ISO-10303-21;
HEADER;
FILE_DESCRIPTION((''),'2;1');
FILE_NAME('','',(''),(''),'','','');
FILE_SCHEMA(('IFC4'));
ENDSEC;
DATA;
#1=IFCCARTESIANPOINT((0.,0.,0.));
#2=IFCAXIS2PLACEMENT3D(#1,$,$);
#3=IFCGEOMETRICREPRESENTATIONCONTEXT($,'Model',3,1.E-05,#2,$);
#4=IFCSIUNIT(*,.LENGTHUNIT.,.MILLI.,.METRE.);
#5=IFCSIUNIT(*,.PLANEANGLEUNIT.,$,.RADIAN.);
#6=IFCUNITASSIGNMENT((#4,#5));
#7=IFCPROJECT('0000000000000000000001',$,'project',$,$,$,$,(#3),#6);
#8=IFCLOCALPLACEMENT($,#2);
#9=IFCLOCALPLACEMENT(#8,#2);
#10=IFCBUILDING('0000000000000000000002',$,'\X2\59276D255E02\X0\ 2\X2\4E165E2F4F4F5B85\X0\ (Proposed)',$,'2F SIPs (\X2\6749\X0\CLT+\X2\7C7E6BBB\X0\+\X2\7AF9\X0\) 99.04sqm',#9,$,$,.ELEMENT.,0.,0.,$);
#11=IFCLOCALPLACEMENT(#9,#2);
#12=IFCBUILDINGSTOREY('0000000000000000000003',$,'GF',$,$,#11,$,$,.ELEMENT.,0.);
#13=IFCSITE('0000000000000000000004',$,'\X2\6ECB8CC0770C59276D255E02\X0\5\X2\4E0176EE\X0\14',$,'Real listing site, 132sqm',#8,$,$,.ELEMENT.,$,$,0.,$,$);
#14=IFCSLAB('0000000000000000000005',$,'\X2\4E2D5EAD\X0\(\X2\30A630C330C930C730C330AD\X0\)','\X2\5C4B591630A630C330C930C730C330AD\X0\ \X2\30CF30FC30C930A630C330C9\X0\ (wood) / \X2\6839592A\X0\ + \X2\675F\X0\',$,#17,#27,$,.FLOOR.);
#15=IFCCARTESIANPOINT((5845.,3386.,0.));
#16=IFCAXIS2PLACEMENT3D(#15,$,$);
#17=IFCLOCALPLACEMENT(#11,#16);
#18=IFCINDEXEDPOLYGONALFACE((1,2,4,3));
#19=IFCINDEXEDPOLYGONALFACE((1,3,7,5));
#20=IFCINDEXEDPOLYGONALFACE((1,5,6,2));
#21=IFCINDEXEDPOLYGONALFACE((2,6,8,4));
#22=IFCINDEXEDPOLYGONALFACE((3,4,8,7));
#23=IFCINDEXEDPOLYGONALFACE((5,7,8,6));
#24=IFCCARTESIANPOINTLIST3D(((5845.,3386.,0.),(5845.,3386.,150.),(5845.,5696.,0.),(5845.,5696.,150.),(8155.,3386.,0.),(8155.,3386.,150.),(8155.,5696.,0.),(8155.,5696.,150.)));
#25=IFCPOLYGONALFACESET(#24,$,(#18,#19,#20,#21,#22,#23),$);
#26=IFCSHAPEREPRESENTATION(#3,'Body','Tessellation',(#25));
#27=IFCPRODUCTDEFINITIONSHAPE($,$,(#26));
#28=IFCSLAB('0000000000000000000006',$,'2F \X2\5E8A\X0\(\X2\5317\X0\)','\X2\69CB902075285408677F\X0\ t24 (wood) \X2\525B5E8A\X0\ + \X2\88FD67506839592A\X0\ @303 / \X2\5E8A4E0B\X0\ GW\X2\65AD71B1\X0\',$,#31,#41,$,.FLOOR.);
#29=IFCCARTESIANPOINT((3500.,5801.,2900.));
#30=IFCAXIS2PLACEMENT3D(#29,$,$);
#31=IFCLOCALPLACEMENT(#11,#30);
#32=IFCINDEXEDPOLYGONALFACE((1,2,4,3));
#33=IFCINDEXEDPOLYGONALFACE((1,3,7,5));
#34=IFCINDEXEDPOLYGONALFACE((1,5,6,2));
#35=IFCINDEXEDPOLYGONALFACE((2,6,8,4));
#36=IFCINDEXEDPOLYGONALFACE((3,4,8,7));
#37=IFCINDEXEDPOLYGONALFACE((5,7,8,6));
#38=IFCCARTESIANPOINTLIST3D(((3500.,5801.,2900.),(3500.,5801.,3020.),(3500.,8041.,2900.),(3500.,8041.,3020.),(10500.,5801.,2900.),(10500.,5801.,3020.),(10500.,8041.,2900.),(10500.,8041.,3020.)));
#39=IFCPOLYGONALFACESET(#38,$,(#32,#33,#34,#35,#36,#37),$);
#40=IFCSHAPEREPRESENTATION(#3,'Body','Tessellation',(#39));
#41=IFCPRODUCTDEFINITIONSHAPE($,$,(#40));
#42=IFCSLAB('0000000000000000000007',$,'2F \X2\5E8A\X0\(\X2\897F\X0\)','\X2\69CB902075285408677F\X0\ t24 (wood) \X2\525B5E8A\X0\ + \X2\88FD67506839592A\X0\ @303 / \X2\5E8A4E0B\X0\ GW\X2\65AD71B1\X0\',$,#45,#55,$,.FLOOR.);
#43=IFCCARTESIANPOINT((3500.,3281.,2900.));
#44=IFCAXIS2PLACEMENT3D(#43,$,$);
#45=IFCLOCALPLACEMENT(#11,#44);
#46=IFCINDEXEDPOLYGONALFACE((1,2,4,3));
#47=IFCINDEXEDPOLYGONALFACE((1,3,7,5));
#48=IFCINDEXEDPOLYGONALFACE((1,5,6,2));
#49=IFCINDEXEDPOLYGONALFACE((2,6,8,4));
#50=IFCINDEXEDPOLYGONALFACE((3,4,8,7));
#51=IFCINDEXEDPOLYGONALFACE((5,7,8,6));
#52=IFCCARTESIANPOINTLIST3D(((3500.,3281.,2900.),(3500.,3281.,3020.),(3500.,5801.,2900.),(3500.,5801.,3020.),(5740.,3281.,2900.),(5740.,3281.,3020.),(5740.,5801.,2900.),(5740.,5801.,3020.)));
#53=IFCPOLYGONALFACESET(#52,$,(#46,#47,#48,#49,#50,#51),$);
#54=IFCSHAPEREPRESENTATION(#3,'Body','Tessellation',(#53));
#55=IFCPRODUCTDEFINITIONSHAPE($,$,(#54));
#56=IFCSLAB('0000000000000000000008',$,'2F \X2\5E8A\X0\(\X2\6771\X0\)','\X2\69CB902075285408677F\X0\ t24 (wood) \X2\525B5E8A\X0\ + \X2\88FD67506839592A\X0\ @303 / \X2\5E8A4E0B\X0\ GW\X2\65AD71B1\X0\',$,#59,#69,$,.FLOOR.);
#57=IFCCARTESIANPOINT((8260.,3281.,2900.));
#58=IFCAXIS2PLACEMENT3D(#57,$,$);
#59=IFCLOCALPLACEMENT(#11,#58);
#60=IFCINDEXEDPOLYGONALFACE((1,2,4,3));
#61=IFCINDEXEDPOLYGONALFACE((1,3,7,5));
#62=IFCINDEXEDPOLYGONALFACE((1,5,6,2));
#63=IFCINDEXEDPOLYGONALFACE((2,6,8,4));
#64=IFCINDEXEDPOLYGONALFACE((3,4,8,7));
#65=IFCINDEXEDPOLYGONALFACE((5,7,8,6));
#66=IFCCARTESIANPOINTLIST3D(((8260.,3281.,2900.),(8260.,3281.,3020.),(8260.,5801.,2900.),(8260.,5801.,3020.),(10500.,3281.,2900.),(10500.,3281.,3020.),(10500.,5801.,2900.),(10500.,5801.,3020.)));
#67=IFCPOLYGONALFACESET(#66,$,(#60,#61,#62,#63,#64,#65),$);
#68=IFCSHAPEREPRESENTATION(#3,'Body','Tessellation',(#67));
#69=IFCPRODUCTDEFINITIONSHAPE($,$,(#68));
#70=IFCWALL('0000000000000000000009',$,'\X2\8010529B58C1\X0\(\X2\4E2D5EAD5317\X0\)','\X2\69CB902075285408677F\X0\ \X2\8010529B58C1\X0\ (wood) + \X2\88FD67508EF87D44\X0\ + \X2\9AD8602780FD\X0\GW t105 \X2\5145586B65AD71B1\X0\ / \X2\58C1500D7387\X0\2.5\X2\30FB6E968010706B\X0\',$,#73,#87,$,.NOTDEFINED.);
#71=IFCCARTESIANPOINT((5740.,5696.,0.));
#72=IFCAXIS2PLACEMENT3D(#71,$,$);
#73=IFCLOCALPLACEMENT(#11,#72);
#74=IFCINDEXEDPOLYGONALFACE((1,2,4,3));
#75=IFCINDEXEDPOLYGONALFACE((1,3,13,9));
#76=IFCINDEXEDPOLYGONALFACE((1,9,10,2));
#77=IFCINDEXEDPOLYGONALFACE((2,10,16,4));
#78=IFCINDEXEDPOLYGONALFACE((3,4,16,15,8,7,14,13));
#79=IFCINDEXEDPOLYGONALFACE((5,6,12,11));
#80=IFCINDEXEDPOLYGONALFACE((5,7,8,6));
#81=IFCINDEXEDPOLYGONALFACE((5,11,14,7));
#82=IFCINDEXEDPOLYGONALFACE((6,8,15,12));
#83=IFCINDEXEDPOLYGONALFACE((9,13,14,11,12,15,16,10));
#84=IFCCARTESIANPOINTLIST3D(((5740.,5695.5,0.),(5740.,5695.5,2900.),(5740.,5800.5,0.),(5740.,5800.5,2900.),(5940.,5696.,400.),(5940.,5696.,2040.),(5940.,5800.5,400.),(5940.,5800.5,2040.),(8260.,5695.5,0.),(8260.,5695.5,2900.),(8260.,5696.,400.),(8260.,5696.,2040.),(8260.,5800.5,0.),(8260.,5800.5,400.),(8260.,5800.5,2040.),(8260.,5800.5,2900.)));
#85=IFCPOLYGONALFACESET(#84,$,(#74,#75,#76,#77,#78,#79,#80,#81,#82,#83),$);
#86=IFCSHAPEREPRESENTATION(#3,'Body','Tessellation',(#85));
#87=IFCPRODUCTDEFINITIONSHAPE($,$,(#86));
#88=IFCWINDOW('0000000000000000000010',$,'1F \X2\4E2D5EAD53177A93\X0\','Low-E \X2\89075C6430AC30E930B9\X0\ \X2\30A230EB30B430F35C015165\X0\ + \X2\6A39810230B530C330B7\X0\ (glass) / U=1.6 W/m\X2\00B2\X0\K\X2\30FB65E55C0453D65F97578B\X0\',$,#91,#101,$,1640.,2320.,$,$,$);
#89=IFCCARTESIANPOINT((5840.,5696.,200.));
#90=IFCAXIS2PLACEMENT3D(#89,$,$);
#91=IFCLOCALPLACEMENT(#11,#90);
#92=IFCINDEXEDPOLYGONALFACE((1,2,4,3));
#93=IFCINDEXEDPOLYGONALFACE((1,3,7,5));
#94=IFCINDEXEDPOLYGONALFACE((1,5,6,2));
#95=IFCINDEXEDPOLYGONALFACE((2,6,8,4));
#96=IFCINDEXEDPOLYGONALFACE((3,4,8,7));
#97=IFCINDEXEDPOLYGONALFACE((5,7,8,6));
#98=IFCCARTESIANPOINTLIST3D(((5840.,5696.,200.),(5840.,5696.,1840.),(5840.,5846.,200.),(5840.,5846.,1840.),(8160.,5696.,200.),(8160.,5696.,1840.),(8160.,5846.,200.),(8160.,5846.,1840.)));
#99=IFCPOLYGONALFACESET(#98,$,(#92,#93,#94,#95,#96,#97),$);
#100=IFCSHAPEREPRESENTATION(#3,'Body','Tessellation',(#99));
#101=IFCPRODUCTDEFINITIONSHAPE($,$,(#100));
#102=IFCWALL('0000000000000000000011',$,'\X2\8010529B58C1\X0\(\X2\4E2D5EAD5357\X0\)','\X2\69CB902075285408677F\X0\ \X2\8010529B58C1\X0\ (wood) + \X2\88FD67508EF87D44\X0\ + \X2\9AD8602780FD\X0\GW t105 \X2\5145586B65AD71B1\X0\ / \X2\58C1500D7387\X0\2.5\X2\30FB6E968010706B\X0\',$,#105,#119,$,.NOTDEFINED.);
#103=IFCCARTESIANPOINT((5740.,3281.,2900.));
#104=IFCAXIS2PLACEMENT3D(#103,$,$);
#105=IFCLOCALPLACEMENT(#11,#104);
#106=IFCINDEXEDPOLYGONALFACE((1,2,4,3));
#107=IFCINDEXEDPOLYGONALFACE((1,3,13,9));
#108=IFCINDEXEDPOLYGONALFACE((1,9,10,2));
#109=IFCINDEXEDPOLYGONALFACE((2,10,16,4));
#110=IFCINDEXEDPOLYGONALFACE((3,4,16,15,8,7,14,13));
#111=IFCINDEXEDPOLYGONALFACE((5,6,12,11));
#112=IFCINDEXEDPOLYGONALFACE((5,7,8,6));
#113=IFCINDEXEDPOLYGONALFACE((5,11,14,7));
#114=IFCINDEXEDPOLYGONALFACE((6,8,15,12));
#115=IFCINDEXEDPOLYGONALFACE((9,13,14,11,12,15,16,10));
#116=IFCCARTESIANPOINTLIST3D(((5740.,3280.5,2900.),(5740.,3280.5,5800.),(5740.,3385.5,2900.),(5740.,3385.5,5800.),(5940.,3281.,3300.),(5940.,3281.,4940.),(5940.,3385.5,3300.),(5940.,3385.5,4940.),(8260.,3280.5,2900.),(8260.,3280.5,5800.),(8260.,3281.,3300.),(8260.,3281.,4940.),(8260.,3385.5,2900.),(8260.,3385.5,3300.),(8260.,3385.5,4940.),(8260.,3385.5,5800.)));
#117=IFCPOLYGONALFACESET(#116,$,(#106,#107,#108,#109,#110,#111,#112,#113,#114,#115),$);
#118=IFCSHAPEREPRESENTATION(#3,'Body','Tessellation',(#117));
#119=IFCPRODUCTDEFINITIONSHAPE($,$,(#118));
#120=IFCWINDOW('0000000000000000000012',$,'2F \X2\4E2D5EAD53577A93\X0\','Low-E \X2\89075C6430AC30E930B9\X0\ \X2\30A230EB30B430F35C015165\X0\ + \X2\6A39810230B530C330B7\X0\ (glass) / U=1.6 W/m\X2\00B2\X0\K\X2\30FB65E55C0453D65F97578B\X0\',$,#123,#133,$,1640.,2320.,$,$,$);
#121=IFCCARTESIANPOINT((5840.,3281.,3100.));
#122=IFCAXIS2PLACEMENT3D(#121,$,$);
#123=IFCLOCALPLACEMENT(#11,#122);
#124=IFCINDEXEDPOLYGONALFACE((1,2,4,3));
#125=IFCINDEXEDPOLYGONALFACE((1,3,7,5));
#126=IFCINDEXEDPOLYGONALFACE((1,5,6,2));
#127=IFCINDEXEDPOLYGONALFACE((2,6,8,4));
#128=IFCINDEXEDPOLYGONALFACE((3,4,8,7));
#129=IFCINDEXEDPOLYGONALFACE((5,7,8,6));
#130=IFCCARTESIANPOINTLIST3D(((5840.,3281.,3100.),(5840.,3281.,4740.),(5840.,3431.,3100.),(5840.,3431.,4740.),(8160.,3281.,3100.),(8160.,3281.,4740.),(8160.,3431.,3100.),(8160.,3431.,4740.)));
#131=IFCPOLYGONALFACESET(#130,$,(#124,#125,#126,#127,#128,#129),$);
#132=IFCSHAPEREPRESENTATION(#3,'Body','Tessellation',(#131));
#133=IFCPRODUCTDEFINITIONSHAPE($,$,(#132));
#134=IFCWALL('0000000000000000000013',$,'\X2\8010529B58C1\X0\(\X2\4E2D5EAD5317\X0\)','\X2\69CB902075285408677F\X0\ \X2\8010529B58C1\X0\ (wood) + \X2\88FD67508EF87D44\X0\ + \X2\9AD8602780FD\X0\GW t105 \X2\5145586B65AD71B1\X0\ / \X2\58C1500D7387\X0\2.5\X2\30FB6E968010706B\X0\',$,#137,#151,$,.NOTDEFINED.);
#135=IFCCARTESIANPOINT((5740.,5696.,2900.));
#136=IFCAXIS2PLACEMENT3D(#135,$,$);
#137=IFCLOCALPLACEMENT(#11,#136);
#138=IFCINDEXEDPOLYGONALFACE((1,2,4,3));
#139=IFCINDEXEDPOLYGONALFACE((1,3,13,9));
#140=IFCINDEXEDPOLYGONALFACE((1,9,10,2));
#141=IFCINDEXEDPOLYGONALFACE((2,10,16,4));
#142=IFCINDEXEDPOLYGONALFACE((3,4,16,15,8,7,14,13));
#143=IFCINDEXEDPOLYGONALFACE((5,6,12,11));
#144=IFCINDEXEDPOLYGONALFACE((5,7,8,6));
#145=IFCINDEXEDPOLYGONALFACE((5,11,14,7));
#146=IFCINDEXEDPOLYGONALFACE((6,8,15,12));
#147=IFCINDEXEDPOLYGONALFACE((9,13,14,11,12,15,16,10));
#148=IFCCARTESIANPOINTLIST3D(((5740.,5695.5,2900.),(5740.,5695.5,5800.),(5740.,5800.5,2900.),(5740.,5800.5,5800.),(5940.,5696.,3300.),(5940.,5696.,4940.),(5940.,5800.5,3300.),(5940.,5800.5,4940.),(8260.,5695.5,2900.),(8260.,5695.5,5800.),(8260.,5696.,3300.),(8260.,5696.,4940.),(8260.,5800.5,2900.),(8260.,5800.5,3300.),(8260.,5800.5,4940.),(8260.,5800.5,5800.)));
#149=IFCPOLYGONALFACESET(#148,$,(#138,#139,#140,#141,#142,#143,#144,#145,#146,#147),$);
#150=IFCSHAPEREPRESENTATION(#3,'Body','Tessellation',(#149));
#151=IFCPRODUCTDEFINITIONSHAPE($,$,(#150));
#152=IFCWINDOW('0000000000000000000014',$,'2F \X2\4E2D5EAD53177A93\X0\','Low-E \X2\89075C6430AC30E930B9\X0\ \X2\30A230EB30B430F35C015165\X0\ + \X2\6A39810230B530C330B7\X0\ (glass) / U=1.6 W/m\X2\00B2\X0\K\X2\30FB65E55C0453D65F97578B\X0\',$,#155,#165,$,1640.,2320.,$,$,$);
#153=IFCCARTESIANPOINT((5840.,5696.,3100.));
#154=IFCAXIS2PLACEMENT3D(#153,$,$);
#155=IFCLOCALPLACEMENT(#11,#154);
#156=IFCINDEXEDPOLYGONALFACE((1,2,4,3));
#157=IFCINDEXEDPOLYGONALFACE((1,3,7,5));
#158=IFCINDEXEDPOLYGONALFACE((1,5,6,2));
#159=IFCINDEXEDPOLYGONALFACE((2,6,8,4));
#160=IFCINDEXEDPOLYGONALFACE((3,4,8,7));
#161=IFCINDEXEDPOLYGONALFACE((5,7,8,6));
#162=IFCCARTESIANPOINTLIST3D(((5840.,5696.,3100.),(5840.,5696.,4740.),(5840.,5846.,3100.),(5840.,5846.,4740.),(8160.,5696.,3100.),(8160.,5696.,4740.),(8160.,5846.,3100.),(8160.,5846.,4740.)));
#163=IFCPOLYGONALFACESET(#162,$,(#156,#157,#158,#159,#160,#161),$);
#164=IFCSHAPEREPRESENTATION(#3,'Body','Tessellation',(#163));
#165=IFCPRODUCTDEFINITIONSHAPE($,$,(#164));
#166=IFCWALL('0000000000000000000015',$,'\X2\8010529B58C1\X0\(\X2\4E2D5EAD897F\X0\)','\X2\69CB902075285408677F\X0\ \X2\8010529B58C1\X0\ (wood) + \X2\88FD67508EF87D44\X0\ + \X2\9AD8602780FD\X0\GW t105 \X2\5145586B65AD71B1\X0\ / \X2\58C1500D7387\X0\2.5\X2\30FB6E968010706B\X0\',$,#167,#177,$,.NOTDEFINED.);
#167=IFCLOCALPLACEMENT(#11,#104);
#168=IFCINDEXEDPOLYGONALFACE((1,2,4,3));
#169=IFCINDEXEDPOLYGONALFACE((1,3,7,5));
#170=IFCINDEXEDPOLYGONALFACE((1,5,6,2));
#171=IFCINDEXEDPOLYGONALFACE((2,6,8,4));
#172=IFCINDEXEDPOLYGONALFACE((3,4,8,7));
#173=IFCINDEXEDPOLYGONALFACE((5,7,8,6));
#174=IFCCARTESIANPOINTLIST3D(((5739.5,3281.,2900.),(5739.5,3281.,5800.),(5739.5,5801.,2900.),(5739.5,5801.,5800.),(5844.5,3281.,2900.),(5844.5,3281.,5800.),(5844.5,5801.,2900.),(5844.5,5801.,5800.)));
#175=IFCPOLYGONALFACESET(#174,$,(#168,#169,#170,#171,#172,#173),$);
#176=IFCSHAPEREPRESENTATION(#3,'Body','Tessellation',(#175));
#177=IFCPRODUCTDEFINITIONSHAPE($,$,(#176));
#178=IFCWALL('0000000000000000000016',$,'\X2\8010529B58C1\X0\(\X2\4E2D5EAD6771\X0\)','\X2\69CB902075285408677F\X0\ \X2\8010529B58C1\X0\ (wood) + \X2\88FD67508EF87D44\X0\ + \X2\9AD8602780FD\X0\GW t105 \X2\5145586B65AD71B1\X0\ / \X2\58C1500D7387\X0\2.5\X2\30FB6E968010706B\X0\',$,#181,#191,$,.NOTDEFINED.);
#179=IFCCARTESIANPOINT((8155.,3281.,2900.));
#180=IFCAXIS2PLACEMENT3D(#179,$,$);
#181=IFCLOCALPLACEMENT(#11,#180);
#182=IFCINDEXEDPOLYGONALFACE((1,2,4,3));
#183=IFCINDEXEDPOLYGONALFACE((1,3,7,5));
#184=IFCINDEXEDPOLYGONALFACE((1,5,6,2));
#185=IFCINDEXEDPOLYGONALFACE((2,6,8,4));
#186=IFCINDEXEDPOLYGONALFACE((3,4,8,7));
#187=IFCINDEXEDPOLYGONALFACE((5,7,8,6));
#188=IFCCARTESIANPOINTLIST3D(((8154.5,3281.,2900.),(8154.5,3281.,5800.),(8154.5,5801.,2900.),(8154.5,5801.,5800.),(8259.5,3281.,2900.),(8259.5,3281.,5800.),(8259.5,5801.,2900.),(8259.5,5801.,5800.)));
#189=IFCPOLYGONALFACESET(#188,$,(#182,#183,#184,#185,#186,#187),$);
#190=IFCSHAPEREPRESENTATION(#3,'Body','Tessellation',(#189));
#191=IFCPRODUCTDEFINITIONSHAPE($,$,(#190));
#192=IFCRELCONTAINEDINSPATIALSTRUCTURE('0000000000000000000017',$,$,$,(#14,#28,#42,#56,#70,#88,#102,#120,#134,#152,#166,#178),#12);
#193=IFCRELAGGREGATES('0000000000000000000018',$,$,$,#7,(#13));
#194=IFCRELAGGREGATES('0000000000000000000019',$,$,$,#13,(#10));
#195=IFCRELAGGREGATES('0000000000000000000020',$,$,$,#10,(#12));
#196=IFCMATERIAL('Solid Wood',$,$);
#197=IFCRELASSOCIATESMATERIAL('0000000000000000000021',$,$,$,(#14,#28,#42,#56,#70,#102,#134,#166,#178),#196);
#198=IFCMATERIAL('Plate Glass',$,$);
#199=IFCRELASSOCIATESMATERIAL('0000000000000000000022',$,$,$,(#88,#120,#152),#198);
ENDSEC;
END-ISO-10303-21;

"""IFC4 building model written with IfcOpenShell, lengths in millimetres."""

from ifc_helpers import new_model, si_unit, frame, frame_2d, origin, place, context, project, spatial, rectangle, extrude, material, element, fill, save


model = new_model("IFC4")

# Units and contexts
model_context = context("Model", 3, precision=1e-05, world=origin())
ifc_project = project(units=[si_unit("LENGTHUNIT", "METRE", prefix="MILLI"), si_unit("PLANEANGLEUNIT", "RADIAN")], contexts=[model_context])

# Site, building, storey
site_placement = place(None, origin())
site = spatial("IfcSite", under=ifc_project, at=site_placement, Name="滋賀県大津市5丁目14", ObjectType="Real listing site, 132sqm", CompositionType="ELEMENT", RefElevation=0.0)
building_placement = place(site_placement, origin())
building = spatial("IfcBuilding", under=site, at=building_placement, Name="大津市 2世帯住宅 (Proposed)", ObjectType="2F SIPs (杉CLT+籾殻+竹) 99.04sqm", CompositionType="ELEMENT", ElevationOfRefHeight=0.0, ElevationOfTerrain=0.0)
storey_placement = place(building_placement, origin())
storey = spatial("IfcBuildingStorey", under=building, at=storey_placement, Name="GF", CompositionType="ELEMENT", Elevation=0.0)

# Slabs
ifc_material_1 = material(Name="Solid Wood")
slab_1_placement = place(storey_placement, frame((5845.0, 3386.0, 0.0)))
element("IfcSlab", 1, at=slab_1_placement, inside=storey, material=ifc_material_1, Name="中庭(ウッドデッキ)", Description="屋外ウッドデッキ ハードウッド (wood) / 根太 + 束", PredefinedType="FLOOR", context=model_context, shape_type="SweptSolid", body=[
    extrude(rectangle(XDim=2310.0, YDim=2310.0, at=frame_2d((1155.0, 1155.0))), frame((5845.0, 3386.0, 0.0)), (0.0, 0.0, 1.0), 150.0),
])
slab_2_placement = place(storey_placement, frame((3500.0, 5801.0, 2900.0)))
element("IfcSlab", 2, at=slab_2_placement, inside=storey, material=ifc_material_1, Name="2F 床(北)", Description="構造用合板 t24 (wood) 剛床 + 製材根太 @303 / 床下 GW断熱", PredefinedType="FLOOR", context=model_context, shape_type="SweptSolid", body=[
    extrude(rectangle(XDim=7000.0, YDim=2240.0, at=frame_2d((3500.0, 1120.0))), frame((3500.0, 5801.0, 2900.0)), (0.0, 0.0, 1.0), 120.0),
])
slab_3_placement = place(storey_placement, frame((3500.0, 3281.0, 2900.0)))
element("IfcSlab", 3, at=slab_3_placement, inside=storey, material=ifc_material_1, Name="2F 床(西)", Description="構造用合板 t24 (wood) 剛床 + 製材根太 @303 / 床下 GW断熱", PredefinedType="FLOOR", context=model_context, shape_type="SweptSolid", body=[
    extrude(rectangle(XDim=2240.0, YDim=2520.0, at=frame_2d((1120.0, 1260.0))), frame((3500.0, 3281.0, 2900.0)), (0.0, 0.0, 1.0), 120.0),
])
slab_4_placement = place(storey_placement, frame((8260.0, 3281.0, 2900.0)))
element("IfcSlab", 4, at=slab_4_placement, inside=storey, material=ifc_material_1, Name="2F 床(東)", Description="構造用合板 t24 (wood) 剛床 + 製材根太 @303 / 床下 GW断熱", PredefinedType="FLOOR", context=model_context, shape_type="SweptSolid", body=[
    extrude(rectangle(XDim=2240.0, YDim=2520.0, at=frame_2d((1120.0, 1260.0))), frame((8260.0, 3281.0, 2900.0)), (0.0, 0.0, 1.0), 120.0),
])

# Wall, opening, window
wall_1_placement = place(storey_placement, frame((5740.0, 5696.0, 0.0)))
wall_1 = element("IfcWall", 5, at=wall_1_placement, inside=storey, material=ifc_material_1, Name="耐力壁(中庭北)", Description="構造用合板 耐力壁 (wood) + 製材軸組 + 高性能GW t105 充填断熱 / 壁倍率2.5・準耐火", PredefinedType="NOTDEFINED", context=model_context, shape_type="SweptSolid", body=[
    extrude(rectangle(XDim=2520.0, YDim=105.0, at=frame_2d((1260.0, 52.0))), frame((5740.0, 5696.0, 0.0)), (0.0, 0.0, 1.0), 2900.0),
])
opening_1_placement = place(storey_placement, frame((5840.0, 5696.0, 200.0)))
opening_1 = element("IfcOpeningElement", 6, at=opening_1_placement, cuts=wall_1, PredefinedType="NOTDEFINED", context=model_context, shape_type="SweptSolid", body=[
    extrude(rectangle(XDim=2320.0, YDim=150.0, at=frame_2d((1160.0, 75.0))), frame((5840.0, 5696.0, 200.0)), (0.0, 0.0, 1.0), 1640.0),
])
ifc_material_2 = material(Name="Plate Glass")
window_1_placement = place(storey_placement, frame((5840.0, 5696.0, 200.0)))
window_1 = element("IfcWindow", 7, at=window_1_placement, inside=storey, material=ifc_material_2, Name="1F 中庭北窓", Description="Low-E 複層ガラス アルゴン封入 + 樹脂サッシ (glass) / U=1.6 W/m²K・日射取得型", OverallHeight=1640.0, OverallWidth=2320.0, context=model_context, shape_type="SweptSolid", body=[
    extrude(rectangle(XDim=2320.0, YDim=150.0, at=frame_2d((1160.0, 75.0))), frame((5840.0, 5696.0, 200.0)), (0.0, 0.0, 1.0), 1640.0),
])
fill(opening_1, window_1)

# Walls, openings, windows
wall_2_placement = place(storey_placement, frame((5740.0, 3281.0, 2900.0)))
wall_2 = element("IfcWall", 8, at=wall_2_placement, inside=storey, material=ifc_material_1, Name="耐力壁(中庭南)", Description="構造用合板 耐力壁 (wood) + 製材軸組 + 高性能GW t105 充填断熱 / 壁倍率2.5・準耐火", PredefinedType="NOTDEFINED", context=model_context, shape_type="SweptSolid", body=[
    extrude(rectangle(XDim=2520.0, YDim=105.0, at=frame_2d((1260.0, 52.0))), frame((5740.0, 3281.0, 2900.0)), (0.0, 0.0, 1.0), 2900.0),
])
opening_2_placement = place(storey_placement, frame((5840.0, 3281.0, 3100.0)))
opening_2 = element("IfcOpeningElement", 9, at=opening_2_placement, cuts=wall_2, PredefinedType="NOTDEFINED", context=model_context, shape_type="SweptSolid", body=[
    extrude(rectangle(XDim=2320.0, YDim=150.0, at=frame_2d((1160.0, 75.0))), frame((5840.0, 3281.0, 3100.0)), (0.0, 0.0, 1.0), 1640.0),
])
window_2_placement = place(storey_placement, frame((5840.0, 3281.0, 3100.0)))
window_2 = element("IfcWindow", 10, at=window_2_placement, inside=storey, material=ifc_material_2, Name="2F 中庭南窓", Description="Low-E 複層ガラス アルゴン封入 + 樹脂サッシ (glass) / U=1.6 W/m²K・日射取得型", OverallHeight=1640.0, OverallWidth=2320.0, context=model_context, shape_type="SweptSolid", body=[
    extrude(rectangle(XDim=2320.0, YDim=150.0, at=frame_2d((1160.0, 75.0))), frame((5840.0, 3281.0, 3100.0)), (0.0, 0.0, 1.0), 1640.0),
])
fill(opening_2, window_2)
wall_3_placement = place(storey_placement, frame((5740.0, 5696.0, 2900.0)))
wall_3 = element("IfcWall", 11, at=wall_3_placement, inside=storey, material=ifc_material_1, Name="耐力壁(中庭北)", Description="構造用合板 耐力壁 (wood) + 製材軸組 + 高性能GW t105 充填断熱 / 壁倍率2.5・準耐火", PredefinedType="NOTDEFINED", context=model_context, shape_type="SweptSolid", body=[
    extrude(rectangle(XDim=2520.0, YDim=105.0, at=frame_2d((1260.0, 52.0))), frame((5740.0, 5696.0, 2900.0)), (0.0, 0.0, 1.0), 2900.0),
])
opening_3_placement = place(storey_placement, frame((5840.0, 5696.0, 3100.0)))
opening_3 = element("IfcOpeningElement", 12, at=opening_3_placement, cuts=wall_3, PredefinedType="NOTDEFINED", context=model_context, shape_type="SweptSolid", body=[
    extrude(rectangle(XDim=2320.0, YDim=150.0, at=frame_2d((1160.0, 75.0))), frame((5840.0, 5696.0, 3100.0)), (0.0, 0.0, 1.0), 1640.0),
])
window_3_placement = place(storey_placement, frame((5840.0, 5696.0, 3100.0)))
window_3 = element("IfcWindow", 13, at=window_3_placement, inside=storey, material=ifc_material_2, Name="2F 中庭北窓", Description="Low-E 複層ガラス アルゴン封入 + 樹脂サッシ (glass) / U=1.6 W/m²K・日射取得型", OverallHeight=1640.0, OverallWidth=2320.0, context=model_context, shape_type="SweptSolid", body=[
    extrude(rectangle(XDim=2320.0, YDim=150.0, at=frame_2d((1160.0, 75.0))), frame((5840.0, 5696.0, 3100.0)), (0.0, 0.0, 1.0), 1640.0),
])
fill(opening_3, window_3)

# Walls
wall_4_placement = place(storey_placement, frame((5740.0, 3281.0, 2900.0)))
element("IfcWall", 14, at=wall_4_placement, inside=storey, material=ifc_material_1, Name="耐力壁(中庭西)", Description="構造用合板 耐力壁 (wood) + 製材軸組 + 高性能GW t105 充填断熱 / 壁倍率2.5・準耐火", PredefinedType="NOTDEFINED", context=model_context, shape_type="SweptSolid", body=[
    extrude(rectangle(XDim=105.0, YDim=2520.0, at=frame_2d((52.0, 1260.0))), frame((5740.0, 3281.0, 2900.0)), (0.0, 0.0, 1.0), 2900.0),
])
wall_5_placement = place(storey_placement, frame((8155.0, 3281.0, 2900.0)))
element("IfcWall", 15, at=wall_5_placement, inside=storey, material=ifc_material_1, Name="耐力壁(中庭東)", Description="構造用合板 耐力壁 (wood) + 製材軸組 + 高性能GW t105 充填断熱 / 壁倍率2.5・準耐火", PredefinedType="NOTDEFINED", context=model_context, shape_type="SweptSolid", body=[
    extrude(rectangle(XDim=105.0, YDim=2520.0, at=frame_2d((52.0, 1260.0))), frame((8155.0, 3281.0, 2900.0)), (0.0, 0.0, 1.0), 2900.0),
])

save(model, "model.ifc")
